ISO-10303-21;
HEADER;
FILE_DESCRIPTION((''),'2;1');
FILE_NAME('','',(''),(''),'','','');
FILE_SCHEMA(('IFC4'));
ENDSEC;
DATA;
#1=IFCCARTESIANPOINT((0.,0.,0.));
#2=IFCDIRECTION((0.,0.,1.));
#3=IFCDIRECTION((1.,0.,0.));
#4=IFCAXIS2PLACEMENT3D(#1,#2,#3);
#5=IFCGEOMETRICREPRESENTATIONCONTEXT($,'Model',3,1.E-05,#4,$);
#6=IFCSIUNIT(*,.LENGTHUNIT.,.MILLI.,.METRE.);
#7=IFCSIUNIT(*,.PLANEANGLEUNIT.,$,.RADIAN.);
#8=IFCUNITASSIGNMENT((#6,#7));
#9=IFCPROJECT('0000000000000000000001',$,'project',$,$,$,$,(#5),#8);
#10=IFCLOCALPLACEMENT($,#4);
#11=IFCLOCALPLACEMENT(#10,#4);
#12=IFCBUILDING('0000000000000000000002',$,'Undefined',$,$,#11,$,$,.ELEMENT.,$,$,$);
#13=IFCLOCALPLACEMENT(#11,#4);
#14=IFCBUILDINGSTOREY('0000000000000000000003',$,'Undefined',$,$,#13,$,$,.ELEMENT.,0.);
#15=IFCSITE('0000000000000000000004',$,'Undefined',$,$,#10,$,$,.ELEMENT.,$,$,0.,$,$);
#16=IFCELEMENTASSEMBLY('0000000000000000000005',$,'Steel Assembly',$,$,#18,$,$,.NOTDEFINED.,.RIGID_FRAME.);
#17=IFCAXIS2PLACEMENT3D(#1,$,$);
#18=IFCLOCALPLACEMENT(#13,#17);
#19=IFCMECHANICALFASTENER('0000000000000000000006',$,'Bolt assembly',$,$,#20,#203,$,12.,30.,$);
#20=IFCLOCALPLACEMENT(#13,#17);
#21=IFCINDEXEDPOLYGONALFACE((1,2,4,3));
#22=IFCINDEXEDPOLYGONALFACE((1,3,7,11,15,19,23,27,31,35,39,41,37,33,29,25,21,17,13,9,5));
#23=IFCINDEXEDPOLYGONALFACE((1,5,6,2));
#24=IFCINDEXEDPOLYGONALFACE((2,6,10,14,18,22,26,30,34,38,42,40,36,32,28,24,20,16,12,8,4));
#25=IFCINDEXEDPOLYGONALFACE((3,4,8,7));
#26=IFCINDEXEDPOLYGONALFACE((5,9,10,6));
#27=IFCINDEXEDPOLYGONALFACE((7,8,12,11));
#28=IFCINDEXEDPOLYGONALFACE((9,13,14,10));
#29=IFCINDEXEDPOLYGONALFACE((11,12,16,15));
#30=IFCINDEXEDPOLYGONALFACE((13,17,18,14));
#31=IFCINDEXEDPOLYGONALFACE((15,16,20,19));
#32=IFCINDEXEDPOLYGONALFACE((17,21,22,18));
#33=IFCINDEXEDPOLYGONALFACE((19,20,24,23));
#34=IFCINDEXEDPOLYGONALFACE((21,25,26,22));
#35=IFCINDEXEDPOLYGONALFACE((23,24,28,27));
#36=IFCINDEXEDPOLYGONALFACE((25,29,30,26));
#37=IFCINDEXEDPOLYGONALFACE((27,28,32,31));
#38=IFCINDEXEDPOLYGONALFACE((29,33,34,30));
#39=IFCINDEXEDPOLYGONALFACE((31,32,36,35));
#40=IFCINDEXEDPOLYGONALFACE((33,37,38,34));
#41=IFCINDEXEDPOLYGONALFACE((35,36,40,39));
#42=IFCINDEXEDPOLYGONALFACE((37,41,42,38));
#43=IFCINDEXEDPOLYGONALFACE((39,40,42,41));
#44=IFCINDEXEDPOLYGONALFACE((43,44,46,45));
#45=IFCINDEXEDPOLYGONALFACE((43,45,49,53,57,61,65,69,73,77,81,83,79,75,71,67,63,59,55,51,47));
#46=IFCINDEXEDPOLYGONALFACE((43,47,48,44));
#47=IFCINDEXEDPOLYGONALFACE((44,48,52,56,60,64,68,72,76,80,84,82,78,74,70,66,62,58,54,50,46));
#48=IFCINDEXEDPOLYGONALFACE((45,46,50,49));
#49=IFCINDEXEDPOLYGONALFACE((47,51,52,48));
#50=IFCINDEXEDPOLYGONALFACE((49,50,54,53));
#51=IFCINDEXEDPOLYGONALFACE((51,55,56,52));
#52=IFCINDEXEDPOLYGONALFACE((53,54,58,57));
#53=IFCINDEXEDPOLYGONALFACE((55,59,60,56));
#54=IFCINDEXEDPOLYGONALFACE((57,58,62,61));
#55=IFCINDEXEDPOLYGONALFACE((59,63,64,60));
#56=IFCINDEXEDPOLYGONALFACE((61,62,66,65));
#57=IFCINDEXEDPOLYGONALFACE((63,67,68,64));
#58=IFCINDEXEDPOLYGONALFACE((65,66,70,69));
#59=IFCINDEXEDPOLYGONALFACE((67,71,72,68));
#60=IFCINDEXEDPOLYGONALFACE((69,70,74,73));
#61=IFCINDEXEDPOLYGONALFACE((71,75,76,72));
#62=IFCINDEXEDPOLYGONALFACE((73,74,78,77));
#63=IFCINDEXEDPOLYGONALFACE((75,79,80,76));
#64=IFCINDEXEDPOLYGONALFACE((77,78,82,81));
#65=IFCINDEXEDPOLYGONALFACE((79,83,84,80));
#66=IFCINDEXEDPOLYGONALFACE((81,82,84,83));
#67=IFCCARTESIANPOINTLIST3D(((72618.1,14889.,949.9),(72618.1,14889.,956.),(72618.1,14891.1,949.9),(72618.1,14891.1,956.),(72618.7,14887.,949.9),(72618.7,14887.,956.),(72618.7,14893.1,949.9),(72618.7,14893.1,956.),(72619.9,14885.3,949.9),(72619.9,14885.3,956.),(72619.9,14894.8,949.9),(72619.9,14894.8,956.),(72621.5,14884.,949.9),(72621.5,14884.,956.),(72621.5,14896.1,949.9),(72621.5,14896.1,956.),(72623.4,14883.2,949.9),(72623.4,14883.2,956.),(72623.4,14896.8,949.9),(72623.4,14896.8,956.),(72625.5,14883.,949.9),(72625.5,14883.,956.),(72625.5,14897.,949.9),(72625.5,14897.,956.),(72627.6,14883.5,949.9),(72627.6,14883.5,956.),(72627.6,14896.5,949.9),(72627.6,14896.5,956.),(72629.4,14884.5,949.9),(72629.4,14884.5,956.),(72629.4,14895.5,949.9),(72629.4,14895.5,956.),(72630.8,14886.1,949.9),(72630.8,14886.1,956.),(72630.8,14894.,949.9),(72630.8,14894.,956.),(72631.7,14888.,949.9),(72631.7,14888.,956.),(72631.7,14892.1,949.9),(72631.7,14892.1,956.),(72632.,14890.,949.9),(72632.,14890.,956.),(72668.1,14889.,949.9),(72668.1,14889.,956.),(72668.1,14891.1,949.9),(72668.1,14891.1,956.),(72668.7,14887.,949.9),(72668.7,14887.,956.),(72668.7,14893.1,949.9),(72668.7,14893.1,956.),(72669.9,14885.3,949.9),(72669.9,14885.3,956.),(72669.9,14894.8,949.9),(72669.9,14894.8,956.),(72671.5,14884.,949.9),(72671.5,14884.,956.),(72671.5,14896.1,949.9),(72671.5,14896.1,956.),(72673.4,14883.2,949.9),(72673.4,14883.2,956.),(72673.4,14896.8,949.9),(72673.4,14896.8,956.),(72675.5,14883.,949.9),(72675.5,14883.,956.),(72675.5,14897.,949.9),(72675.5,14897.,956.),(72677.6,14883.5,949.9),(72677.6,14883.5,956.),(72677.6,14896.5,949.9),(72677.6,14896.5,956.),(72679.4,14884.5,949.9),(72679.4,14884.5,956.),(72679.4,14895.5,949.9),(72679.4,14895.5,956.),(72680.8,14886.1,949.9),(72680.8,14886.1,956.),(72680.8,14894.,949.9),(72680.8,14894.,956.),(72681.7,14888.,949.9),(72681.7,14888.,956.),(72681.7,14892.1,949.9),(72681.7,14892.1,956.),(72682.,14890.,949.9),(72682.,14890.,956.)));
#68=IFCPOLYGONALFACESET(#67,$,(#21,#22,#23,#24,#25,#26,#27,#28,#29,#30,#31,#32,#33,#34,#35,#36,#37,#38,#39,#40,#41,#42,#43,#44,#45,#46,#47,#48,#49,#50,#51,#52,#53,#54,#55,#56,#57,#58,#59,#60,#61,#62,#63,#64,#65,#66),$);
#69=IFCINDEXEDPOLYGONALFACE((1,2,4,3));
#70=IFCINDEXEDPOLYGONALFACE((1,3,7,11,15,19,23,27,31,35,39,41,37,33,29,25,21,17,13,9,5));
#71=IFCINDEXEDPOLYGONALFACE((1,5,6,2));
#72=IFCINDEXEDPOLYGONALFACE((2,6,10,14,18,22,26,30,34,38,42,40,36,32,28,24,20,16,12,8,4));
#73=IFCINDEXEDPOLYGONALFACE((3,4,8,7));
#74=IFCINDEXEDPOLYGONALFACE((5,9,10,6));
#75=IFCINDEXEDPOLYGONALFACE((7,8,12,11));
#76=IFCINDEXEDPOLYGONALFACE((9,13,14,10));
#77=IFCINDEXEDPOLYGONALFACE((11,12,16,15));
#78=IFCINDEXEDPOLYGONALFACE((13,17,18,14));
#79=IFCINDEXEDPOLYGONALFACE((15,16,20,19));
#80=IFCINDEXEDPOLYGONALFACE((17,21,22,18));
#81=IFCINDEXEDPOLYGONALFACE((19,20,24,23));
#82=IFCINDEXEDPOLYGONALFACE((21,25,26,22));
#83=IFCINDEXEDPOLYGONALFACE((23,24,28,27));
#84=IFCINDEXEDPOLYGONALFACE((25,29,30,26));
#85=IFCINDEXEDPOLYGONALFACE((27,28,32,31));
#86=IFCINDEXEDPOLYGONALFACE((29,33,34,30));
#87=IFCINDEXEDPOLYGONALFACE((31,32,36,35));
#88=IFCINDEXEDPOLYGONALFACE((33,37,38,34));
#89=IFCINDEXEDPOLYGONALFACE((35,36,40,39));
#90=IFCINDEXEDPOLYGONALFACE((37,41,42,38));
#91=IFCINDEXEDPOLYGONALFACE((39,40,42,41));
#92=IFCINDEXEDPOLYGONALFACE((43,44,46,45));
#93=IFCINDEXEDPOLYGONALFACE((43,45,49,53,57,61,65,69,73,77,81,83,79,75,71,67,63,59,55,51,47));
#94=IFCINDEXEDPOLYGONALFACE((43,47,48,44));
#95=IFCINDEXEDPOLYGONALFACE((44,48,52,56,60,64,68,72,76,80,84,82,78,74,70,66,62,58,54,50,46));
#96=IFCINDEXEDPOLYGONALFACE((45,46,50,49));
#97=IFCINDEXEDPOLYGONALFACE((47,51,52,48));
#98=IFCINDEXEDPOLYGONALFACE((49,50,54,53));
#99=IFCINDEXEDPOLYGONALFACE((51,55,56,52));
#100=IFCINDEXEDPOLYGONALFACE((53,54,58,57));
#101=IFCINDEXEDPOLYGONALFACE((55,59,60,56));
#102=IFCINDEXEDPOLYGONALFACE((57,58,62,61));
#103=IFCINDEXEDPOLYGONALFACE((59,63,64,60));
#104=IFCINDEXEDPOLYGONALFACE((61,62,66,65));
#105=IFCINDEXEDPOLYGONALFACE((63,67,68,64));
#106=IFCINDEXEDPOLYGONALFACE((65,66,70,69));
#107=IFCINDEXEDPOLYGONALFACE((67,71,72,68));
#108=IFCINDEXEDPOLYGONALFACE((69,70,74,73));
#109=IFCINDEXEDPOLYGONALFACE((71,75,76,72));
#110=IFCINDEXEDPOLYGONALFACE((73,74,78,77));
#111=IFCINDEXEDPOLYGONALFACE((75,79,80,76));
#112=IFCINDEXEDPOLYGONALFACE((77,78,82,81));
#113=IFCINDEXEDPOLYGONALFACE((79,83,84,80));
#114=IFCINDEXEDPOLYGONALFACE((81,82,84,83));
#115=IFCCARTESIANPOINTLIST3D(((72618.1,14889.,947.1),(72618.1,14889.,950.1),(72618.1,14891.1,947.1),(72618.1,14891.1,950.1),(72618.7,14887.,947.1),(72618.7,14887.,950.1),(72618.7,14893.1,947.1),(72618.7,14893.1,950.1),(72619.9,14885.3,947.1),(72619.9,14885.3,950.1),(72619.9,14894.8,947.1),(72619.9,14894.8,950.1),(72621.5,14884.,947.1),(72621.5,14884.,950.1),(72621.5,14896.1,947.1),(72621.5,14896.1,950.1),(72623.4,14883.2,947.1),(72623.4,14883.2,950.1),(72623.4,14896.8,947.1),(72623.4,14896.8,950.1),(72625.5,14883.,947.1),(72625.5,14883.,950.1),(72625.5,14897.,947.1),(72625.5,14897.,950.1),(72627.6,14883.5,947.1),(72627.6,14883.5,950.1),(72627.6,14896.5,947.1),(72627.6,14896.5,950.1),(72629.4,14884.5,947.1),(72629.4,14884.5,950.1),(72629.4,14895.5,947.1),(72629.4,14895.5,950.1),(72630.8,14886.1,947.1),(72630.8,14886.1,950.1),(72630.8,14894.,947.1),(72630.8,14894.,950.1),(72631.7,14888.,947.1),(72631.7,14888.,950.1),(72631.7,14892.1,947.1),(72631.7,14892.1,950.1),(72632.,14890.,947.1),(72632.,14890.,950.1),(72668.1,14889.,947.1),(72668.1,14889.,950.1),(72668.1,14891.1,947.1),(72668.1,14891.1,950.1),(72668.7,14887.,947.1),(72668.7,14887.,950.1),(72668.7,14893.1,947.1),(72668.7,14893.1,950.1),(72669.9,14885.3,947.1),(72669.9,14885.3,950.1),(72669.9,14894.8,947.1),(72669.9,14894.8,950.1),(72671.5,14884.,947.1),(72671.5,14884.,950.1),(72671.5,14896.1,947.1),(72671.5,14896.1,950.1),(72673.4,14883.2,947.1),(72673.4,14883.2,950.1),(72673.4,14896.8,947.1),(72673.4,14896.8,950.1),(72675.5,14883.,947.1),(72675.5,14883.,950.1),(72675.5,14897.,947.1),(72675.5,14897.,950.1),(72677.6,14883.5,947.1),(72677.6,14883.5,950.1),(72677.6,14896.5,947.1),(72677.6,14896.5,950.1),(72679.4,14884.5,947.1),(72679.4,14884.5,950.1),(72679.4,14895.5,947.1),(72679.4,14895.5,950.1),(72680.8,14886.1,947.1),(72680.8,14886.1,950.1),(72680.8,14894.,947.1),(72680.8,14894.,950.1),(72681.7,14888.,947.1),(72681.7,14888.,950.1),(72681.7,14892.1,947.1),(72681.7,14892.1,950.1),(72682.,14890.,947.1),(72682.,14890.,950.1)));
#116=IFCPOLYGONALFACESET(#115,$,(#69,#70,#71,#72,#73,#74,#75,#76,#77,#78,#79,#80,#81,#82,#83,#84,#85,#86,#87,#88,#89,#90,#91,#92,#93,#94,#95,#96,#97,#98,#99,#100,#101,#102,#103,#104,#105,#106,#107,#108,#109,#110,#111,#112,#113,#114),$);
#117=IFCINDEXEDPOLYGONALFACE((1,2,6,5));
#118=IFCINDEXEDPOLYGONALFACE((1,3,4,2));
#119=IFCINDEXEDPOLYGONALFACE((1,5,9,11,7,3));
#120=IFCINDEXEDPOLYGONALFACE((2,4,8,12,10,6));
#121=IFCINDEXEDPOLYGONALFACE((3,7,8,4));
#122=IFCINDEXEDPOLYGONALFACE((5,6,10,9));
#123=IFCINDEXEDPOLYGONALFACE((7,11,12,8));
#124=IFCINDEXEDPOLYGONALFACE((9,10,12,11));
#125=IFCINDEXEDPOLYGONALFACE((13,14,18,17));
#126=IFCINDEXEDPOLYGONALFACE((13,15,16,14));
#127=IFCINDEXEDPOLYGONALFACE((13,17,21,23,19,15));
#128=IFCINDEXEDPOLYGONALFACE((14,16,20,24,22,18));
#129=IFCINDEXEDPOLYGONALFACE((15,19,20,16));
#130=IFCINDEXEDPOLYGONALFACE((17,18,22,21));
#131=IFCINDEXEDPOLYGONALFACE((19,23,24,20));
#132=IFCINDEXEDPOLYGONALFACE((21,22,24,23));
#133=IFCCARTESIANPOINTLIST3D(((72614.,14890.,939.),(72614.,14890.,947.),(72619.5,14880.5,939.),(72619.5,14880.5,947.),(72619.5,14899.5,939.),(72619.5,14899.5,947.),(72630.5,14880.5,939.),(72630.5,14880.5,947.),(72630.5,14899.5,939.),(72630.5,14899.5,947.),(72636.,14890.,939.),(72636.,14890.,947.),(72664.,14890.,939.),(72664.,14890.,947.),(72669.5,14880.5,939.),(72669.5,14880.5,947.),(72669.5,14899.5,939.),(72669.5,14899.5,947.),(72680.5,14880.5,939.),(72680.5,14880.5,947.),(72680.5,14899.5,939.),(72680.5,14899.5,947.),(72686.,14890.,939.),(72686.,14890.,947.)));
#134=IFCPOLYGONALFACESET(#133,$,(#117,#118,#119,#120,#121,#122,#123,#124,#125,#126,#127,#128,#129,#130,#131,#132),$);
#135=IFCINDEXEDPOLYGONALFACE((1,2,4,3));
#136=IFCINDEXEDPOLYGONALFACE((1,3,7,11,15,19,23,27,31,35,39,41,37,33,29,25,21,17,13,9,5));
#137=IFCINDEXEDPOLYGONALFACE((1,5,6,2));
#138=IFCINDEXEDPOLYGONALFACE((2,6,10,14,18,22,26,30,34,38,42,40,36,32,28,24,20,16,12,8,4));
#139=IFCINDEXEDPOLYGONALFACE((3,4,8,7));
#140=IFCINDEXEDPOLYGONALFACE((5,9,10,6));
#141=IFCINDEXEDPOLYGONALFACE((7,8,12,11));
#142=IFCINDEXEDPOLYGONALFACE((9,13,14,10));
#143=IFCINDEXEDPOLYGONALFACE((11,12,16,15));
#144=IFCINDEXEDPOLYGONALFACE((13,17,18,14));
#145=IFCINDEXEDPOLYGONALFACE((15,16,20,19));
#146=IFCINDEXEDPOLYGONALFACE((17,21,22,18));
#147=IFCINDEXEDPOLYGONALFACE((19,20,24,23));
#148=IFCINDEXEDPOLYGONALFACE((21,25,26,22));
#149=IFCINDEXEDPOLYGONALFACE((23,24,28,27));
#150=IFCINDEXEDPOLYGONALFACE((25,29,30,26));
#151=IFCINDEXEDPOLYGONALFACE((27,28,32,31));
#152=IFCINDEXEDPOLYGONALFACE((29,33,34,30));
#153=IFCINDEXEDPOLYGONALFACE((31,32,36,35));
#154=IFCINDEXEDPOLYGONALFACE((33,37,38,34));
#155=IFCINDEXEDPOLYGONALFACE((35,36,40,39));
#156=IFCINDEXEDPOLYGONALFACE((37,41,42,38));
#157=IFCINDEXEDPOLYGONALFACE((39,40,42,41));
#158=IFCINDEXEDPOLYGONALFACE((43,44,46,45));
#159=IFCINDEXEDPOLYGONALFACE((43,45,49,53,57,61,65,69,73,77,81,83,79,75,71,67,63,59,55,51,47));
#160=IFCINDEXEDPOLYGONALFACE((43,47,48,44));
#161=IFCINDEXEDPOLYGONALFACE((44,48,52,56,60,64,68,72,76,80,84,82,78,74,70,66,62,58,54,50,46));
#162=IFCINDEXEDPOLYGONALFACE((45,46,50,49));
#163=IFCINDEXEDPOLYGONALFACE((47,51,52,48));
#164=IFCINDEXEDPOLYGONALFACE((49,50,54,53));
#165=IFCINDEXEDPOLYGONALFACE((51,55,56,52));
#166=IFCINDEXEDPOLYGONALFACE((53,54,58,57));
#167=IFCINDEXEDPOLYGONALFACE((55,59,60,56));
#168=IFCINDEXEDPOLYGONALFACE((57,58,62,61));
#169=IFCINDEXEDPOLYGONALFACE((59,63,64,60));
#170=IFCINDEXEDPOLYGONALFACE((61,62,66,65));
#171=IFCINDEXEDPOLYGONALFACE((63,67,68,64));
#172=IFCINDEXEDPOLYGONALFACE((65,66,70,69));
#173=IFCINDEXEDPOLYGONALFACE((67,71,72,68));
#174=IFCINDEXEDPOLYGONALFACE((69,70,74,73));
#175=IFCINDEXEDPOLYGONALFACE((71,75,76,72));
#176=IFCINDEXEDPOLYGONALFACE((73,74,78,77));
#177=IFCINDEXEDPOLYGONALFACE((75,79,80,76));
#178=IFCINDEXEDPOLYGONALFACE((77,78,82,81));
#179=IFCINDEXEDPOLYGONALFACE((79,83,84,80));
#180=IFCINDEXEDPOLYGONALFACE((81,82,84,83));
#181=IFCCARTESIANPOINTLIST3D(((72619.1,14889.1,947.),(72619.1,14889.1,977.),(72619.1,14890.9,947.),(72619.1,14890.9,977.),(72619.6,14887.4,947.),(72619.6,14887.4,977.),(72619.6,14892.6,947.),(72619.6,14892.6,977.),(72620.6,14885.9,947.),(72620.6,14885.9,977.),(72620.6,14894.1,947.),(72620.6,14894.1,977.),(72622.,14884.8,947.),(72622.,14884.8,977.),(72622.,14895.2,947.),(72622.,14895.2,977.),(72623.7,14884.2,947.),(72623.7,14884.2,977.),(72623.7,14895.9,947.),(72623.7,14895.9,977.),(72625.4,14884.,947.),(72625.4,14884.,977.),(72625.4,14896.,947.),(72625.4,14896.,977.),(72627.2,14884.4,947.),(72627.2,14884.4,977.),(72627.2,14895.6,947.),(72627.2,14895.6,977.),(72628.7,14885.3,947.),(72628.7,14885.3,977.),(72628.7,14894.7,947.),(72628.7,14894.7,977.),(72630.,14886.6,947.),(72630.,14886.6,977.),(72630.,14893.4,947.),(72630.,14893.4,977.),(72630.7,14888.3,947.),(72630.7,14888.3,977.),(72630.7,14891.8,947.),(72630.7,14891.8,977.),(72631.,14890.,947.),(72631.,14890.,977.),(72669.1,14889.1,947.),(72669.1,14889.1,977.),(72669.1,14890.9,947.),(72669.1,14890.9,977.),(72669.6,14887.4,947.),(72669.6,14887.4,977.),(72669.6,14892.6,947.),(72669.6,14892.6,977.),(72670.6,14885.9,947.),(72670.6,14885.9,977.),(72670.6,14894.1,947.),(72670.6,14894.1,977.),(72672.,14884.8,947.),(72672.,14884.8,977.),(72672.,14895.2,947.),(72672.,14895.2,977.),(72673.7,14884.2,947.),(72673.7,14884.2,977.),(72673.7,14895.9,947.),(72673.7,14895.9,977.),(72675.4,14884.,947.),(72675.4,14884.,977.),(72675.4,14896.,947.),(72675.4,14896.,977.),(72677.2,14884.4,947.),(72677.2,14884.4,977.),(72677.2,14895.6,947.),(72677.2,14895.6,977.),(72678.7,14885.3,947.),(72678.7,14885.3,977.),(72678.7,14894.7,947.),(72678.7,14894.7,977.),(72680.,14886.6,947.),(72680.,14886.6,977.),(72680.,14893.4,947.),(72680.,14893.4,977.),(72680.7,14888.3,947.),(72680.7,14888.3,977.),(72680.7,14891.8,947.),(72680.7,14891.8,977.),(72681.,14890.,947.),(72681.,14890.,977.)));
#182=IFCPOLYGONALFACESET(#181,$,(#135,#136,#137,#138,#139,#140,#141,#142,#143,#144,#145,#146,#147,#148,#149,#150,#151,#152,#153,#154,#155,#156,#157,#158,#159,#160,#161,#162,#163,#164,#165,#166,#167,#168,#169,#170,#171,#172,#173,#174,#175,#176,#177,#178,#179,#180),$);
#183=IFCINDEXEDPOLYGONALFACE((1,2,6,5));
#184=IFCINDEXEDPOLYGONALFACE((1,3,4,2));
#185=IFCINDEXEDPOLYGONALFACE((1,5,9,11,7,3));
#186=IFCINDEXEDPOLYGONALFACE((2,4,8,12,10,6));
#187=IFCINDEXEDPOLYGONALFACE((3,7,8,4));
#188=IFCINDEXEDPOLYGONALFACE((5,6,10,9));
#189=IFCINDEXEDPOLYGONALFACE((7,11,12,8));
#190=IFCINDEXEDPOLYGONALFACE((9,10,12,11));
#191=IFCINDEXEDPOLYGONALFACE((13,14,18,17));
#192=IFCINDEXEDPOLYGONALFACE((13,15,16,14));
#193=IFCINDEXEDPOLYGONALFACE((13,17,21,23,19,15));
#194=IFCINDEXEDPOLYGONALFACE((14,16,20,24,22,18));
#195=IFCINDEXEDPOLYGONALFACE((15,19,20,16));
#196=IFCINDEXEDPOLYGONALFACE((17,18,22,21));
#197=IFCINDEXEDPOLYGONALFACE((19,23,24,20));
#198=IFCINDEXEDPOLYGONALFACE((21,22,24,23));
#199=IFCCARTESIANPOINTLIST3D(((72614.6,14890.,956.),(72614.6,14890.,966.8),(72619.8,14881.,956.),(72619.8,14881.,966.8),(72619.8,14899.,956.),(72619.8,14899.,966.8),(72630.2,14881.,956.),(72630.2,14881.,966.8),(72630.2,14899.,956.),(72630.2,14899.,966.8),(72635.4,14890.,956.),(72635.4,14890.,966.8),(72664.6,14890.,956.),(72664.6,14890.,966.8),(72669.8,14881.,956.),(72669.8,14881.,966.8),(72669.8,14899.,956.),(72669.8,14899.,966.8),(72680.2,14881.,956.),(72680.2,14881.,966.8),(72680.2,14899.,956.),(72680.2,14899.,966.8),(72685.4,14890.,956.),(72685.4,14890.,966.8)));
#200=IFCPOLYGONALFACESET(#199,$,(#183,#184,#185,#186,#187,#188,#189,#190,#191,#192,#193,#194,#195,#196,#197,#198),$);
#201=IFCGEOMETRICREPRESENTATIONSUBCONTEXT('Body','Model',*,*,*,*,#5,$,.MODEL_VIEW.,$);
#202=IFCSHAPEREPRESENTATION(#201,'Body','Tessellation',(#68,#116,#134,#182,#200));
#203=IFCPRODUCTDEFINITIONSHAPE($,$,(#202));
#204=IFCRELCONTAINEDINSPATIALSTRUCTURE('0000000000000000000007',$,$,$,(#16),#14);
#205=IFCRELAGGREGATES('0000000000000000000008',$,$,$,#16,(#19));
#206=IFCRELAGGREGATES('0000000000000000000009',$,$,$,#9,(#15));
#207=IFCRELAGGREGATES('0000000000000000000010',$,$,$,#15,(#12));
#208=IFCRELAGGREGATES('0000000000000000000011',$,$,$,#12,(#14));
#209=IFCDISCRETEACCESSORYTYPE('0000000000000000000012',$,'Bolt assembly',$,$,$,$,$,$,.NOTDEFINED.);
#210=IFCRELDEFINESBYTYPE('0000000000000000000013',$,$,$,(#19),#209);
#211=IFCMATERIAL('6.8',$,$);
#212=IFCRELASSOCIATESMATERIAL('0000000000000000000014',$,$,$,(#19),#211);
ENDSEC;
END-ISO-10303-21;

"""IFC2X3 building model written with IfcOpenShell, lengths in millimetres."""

from ifc_helpers import new_model, si_unit, frame, origin_with_axes, origin_2d_with_axis, place, context, subcontext, project, spatial, polyline, circle, outline, extrude, source, transform, mapped, material, type_object, element, aggregate, save


model = new_model("IFC2X3")

# Units and contexts
model_context = context("Model", 3, precision=1e-05, world=origin_with_axes())
body_context = subcontext(model_context, "Body", "Model", "MODEL_VIEW")
ifc_project = project(units=[si_unit("LENGTHUNIT", "METRE", prefix="MILLI"), si_unit("PLANEANGLEUNIT", "RADIAN")], contexts=[model_context])

# Site, building, storey
site_placement = place(None, origin_with_axes())
site = spatial("IfcSite", under=ifc_project, at=site_placement, Name="Undefined", CompositionType="ELEMENT", RefElevation=0.0)
building_placement = place(site_placement, origin_with_axes())
building = spatial("IfcBuilding", under=site, at=building_placement, Name="Undefined", CompositionType="ELEMENT")
storey_placement = place(building_placement, origin_with_axes())
storey = spatial("IfcBuildingStorey", under=building, at=storey_placement, Name="Undefined", CompositionType="ELEMENT", Elevation=0.0)

# Element assembly
assembly_1_placement = place(storey_placement, origin_with_axes())
assembly_1 = element("IfcElementAssembly", 1, at=assembly_1_placement, inside=storey, Name="Steel Assembly", AssemblyPlace="NOTDEFINED", PredefinedType="RIGID_FRAME")

# Shared definitions
ifc_material_1 = material(Name="6.8")
discrete_accessory_type_1 = type_object("IfcDiscreteAccessoryType", Name="Bolt assembly")

# Mechanical fastener
shared_shape_1 = source(origin_with_axes(), body_context, "Body", "SweptSolid", [
    extrude(circle(Radius=7.0, at=origin_2d_with_axis()), frame((0.0, -6.1, 0.0), z_axis=(0.0, 1.0, 0.0), x_axis=(1.0, 0.0, 0.0)), (0.0, 0.0, 1.0), 6.1),
    extrude(circle(Radius=7.0, at=origin_2d_with_axis()), frame((0.0, -8.9, 0.0), z_axis=(0.0, 1.0, 0.0), x_axis=(1.0, 0.0, 0.0)), (0.0, 0.0, 1.0), 3.0),
    extrude(outline(polyline([(11.0, 0.0), (5.5, 9.5), (-5.5, 9.5), (-11.0, 0.0), (-5.5, -9.5), (5.5, -9.5), (11.0, 0.0)])), frame((0.0, -17.0, 0.0), z_axis=(0.0, 1.0, 0.0), x_axis=(1.0, 0.0, 0.0)), (0.0, 0.0, 1.0), 8.0),
    extrude(circle(Radius=6.0, at=origin_2d_with_axis()), frame((0.0, -9.0, 0.0), z_axis=(0.0, 1.0, 0.0), x_axis=(1.0, 0.0, 0.0)), (0.0, 0.0, 1.0), 30.0),
    extrude(outline(polyline([(10.4, 0.0), (5.2, 9.0), (-5.2, 9.0), (-10.4, 0.0), (-5.2, -9.0), (5.2, -9.0), (10.4, 0.0)])), frame((0.0, 0.0, 0.0), z_axis=(0.0, 1.0, 0.0), x_axis=(1.0, 0.0, 0.0)), (0.0, 0.0, 1.0), 10.8),
])
mechanical_fastener_1_placement = place(assembly_1_placement, frame((72625.0, 14890.0, 956.0), z_axis=(0.0, -1.0, 0.0), x_axis=(1.0, 0.0, 0.0)))
mechanical_fastener_1 = element("IfcMechanicalFastener", 2, at=mechanical_fastener_1_placement, type_object=discrete_accessory_type_1, material=ifc_material_1, Name="Bolt assembly", NominalDiameter=12.0, NominalLength=30.0, context=body_context, shape_type="MappedRepresentation", body=[
    mapped(shared_shape_1, transform((0.0, 0.0, 0.0))),
    mapped(shared_shape_1, transform((50.0, 0.0, 0.0))),
])
aggregate(assembly_1, [mechanical_fastener_1])

save(model, "model.ifc")
